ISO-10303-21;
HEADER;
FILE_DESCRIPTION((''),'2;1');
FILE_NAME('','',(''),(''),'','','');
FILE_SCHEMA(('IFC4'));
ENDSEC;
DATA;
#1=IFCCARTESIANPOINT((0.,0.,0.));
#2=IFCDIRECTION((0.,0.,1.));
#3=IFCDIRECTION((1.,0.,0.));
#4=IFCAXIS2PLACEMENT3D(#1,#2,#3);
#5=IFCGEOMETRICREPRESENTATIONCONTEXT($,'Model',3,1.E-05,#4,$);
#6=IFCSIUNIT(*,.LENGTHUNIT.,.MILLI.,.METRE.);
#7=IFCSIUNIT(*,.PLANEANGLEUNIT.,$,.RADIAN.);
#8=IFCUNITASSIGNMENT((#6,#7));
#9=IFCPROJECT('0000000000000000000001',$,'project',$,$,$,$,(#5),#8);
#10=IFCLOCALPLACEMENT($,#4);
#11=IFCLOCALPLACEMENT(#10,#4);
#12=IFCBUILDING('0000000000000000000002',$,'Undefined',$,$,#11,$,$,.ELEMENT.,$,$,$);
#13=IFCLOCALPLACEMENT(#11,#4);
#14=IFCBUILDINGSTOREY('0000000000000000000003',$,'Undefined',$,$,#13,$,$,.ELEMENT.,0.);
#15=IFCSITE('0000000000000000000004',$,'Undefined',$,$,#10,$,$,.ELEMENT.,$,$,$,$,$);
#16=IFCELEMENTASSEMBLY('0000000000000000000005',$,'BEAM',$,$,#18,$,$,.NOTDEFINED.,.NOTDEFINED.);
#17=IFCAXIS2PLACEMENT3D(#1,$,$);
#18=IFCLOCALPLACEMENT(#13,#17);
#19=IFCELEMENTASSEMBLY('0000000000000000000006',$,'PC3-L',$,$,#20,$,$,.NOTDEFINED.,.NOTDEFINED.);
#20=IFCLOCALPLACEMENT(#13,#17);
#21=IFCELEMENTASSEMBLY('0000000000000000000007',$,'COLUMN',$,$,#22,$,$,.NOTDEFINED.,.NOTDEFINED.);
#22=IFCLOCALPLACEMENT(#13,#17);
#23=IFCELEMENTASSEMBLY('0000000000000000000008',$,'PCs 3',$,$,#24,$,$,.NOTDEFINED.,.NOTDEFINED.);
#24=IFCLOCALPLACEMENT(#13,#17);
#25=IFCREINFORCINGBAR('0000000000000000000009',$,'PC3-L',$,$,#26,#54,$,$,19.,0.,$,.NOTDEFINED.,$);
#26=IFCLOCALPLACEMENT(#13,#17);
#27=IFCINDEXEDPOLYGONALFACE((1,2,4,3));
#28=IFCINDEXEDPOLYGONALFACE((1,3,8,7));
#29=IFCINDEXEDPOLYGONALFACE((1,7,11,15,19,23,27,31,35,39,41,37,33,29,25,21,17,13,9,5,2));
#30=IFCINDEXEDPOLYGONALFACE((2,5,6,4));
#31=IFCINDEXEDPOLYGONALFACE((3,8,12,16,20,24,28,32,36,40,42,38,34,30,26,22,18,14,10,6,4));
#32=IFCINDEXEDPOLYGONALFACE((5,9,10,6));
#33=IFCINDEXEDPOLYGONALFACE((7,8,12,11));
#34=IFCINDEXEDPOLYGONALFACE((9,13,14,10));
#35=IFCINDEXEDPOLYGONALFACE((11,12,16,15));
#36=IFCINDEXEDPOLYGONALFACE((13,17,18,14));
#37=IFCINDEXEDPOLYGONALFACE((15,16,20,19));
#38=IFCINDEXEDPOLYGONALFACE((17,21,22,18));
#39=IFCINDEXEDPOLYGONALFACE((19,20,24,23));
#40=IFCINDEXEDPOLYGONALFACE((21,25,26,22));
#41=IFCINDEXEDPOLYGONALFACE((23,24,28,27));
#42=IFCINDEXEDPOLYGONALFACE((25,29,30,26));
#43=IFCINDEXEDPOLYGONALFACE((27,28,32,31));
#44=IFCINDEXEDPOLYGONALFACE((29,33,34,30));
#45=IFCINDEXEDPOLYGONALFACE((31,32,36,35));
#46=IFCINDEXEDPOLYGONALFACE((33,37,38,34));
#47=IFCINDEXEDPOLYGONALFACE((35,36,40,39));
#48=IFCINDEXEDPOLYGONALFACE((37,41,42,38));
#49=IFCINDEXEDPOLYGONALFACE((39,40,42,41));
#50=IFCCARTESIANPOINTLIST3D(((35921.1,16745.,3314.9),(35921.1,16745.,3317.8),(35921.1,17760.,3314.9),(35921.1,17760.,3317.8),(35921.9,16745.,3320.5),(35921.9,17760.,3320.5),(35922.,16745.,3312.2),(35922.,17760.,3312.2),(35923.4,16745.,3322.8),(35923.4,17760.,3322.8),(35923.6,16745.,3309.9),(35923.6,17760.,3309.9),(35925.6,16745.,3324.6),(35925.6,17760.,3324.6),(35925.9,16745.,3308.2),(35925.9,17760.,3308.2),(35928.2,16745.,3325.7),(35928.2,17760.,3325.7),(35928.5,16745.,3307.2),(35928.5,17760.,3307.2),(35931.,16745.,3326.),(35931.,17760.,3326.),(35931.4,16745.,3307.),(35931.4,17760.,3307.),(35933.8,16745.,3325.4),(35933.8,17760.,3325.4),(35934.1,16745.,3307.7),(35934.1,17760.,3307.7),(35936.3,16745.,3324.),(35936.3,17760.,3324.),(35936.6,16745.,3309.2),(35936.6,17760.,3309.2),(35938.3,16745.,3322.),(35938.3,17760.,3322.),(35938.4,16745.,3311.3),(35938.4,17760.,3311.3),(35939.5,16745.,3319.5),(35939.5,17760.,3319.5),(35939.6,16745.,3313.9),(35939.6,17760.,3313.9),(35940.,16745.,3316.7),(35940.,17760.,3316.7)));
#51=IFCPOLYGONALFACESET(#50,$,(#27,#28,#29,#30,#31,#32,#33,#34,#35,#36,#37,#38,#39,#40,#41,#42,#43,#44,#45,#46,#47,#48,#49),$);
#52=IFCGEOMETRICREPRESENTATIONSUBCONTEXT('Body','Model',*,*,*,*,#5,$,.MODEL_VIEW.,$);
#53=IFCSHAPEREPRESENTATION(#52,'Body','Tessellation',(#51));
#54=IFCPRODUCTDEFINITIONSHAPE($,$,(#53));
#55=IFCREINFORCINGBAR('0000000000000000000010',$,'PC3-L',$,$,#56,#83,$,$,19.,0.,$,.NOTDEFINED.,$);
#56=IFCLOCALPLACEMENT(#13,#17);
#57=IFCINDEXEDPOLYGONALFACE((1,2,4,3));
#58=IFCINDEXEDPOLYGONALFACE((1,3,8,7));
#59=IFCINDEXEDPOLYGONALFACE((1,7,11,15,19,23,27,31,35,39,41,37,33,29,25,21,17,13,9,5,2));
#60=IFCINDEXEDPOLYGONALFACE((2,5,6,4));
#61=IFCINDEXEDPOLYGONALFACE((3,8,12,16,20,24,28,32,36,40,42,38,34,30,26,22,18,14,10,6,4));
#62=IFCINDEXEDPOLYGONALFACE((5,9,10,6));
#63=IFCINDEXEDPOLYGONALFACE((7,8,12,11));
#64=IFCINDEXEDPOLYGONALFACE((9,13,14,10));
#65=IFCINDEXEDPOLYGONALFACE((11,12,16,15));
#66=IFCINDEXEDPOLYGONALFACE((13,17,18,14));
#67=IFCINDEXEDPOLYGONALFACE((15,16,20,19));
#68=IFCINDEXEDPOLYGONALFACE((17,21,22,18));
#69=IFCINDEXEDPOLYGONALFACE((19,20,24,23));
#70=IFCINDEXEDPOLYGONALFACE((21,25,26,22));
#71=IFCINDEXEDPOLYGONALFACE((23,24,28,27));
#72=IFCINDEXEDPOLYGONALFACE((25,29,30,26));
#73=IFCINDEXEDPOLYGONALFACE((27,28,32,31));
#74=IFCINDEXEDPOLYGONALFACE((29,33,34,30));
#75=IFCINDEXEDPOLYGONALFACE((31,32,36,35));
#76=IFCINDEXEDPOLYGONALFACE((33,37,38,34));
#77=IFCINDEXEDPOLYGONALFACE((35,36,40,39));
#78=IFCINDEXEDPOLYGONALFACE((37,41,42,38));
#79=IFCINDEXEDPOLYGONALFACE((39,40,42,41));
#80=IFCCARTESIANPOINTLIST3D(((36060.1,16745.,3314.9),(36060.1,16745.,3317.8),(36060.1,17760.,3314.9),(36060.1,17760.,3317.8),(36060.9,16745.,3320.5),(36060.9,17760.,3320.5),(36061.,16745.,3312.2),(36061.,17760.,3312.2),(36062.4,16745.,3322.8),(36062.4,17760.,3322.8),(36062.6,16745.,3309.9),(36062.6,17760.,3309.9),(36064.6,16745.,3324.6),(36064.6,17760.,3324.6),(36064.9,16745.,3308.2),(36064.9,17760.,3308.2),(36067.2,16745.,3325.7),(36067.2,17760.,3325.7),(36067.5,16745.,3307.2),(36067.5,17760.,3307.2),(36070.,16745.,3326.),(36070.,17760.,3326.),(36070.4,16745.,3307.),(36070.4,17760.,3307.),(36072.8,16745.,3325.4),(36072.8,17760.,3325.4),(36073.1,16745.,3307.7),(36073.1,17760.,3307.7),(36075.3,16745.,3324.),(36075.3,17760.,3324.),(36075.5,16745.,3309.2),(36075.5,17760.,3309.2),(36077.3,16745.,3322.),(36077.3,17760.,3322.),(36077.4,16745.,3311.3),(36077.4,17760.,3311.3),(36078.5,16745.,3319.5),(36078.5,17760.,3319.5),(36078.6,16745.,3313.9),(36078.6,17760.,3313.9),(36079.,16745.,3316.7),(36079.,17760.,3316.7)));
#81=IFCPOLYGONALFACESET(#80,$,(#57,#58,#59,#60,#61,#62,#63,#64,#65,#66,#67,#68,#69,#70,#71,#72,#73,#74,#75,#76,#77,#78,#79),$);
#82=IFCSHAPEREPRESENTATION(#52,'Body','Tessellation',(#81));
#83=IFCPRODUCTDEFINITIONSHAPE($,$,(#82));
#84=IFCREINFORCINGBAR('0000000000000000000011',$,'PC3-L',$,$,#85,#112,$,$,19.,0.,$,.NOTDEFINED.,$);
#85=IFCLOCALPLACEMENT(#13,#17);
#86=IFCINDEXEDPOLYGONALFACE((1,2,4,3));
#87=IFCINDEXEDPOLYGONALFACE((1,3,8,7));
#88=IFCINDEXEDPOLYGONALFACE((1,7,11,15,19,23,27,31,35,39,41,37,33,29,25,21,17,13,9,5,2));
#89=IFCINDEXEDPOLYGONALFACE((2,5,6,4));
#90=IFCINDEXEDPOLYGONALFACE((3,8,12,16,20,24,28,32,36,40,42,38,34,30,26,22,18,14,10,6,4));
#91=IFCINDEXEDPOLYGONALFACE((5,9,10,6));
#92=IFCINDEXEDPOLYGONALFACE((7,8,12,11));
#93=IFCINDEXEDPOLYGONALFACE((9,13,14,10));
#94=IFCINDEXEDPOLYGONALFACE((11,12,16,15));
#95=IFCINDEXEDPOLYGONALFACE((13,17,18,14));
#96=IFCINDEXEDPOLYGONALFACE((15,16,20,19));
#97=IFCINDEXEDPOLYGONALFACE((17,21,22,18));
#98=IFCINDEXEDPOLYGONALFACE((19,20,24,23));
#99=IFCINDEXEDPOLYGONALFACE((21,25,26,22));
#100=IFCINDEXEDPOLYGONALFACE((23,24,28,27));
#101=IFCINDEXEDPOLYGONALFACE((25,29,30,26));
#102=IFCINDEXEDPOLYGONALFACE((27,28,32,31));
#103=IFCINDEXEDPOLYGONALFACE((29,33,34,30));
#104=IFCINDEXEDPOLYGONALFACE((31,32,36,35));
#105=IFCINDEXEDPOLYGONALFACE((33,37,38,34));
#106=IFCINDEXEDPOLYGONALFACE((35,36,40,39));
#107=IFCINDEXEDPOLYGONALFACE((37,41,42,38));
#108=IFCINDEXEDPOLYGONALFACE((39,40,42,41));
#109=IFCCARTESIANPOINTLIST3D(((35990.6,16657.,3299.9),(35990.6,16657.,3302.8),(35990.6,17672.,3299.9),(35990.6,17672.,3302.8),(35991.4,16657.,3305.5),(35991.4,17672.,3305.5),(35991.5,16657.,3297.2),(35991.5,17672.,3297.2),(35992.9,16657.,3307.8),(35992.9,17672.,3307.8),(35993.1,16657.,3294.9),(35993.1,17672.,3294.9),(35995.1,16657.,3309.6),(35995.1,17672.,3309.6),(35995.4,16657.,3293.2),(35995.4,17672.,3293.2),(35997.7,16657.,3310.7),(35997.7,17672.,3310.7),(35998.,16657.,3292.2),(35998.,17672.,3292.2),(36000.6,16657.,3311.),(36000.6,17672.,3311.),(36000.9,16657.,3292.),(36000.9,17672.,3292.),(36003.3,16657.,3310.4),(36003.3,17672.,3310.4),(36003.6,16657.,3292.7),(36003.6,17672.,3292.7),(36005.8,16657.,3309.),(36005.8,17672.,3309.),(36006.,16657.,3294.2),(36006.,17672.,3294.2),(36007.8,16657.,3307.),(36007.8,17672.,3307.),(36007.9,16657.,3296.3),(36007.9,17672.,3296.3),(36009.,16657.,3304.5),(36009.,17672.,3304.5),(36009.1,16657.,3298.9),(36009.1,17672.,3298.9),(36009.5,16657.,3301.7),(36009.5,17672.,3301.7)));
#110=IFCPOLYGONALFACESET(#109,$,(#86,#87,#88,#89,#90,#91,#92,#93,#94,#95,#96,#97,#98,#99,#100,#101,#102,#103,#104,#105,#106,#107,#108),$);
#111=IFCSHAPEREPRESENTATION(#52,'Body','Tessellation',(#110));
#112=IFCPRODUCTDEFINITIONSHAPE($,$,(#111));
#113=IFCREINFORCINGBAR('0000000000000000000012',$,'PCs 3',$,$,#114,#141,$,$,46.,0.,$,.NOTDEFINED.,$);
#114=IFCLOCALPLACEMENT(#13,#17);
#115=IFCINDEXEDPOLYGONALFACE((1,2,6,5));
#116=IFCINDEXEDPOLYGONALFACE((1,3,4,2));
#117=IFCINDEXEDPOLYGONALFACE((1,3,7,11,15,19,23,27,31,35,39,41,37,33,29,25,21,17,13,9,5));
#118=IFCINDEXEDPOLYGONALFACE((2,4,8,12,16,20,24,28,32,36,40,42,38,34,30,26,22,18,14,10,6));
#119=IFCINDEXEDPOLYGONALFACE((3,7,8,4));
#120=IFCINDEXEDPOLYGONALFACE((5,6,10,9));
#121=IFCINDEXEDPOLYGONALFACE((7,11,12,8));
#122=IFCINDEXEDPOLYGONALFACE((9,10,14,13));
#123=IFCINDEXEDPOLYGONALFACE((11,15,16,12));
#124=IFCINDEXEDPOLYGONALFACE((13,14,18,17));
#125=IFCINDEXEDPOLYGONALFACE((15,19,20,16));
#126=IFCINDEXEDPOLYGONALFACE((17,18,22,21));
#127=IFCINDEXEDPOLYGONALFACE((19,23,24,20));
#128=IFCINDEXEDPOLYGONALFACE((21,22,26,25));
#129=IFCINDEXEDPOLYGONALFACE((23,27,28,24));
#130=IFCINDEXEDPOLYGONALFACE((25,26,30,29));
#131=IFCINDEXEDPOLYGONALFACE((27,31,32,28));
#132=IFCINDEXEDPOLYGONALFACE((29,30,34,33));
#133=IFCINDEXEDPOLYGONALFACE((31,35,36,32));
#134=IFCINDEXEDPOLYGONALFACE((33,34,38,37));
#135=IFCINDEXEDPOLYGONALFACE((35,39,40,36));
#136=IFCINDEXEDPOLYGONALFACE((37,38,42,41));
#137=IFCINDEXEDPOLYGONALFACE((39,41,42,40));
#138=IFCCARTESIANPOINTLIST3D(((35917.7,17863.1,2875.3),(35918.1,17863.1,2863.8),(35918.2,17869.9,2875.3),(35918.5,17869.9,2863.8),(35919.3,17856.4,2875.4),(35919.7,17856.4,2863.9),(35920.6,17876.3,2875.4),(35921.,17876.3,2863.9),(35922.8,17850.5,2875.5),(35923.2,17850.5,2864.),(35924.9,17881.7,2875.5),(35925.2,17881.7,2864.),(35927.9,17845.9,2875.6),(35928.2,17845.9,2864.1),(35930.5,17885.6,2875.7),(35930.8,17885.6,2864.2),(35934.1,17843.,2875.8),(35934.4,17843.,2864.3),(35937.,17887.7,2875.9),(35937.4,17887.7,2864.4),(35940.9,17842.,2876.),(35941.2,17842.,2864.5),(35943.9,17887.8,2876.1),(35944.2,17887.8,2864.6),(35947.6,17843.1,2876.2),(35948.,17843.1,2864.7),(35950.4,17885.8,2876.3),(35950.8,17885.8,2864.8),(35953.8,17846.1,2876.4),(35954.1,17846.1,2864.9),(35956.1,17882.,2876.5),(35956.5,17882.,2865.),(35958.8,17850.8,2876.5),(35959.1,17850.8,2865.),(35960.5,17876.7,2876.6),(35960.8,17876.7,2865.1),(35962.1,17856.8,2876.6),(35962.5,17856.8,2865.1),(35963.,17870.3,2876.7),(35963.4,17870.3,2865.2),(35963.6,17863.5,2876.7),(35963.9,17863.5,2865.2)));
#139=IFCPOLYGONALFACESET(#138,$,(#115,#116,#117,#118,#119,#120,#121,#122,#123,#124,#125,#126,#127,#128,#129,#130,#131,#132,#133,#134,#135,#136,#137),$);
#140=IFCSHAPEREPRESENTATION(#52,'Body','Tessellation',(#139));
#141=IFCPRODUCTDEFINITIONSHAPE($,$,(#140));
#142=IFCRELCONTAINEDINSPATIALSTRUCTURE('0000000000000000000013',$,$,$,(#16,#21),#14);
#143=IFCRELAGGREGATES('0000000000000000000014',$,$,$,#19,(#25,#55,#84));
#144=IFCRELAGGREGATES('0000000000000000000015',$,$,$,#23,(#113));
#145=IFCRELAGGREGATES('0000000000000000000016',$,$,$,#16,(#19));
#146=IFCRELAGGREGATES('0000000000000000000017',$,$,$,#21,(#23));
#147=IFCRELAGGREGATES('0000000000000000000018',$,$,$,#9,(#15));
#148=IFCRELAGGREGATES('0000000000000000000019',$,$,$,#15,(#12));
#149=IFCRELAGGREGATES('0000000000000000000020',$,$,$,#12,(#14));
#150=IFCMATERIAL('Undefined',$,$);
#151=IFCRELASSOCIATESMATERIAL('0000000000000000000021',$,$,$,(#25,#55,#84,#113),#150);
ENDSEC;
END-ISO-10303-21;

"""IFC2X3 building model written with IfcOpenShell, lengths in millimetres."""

from ifc_helpers import new_model, entity, si_unit, frame, origin_with_axes, place, context, subcontext, project, spatial, source, transform, mapped, material, element, aggregate, save


model = new_model("IFC2X3")

# Units and contexts
model_context = context("Model", 3, precision=1e-05, world=origin_with_axes())
body_context = subcontext(model_context, "Body", "Model", "MODEL_VIEW")
ifc_project = project(units=[si_unit("LENGTHUNIT", "METRE", prefix="MILLI"), si_unit("PLANEANGLEUNIT", "RADIAN")], contexts=[model_context])

# Site, building, storey
site_placement = place(None, origin_with_axes())
site = spatial("IfcSite", under=ifc_project, at=site_placement, Name="Undefined", CompositionType="ELEMENT")
building_placement = place(site_placement, origin_with_axes())
building = spatial("IfcBuilding", under=site, at=building_placement, Name="Undefined", CompositionType="ELEMENT")
storey_placement = place(building_placement, origin_with_axes())
storey = spatial("IfcBuildingStorey", under=building, at=storey_placement, Name="Undefined", CompositionType="ELEMENT", Elevation=0.0)

# Element assemblies
assembly_1_placement = place(storey_placement, origin_with_axes())
assembly_1 = element("IfcElementAssembly", 1, at=assembly_1_placement, inside=storey, Name="BEAM", AssemblyPlace="NOTDEFINED", PredefinedType="NOTDEFINED")
assembly_2_placement = place(assembly_1_placement, origin_with_axes())
assembly_2 = element("IfcElementAssembly", 2, at=assembly_2_placement, Name="PC3-L", AssemblyPlace="NOTDEFINED", PredefinedType="NOTDEFINED")

# Element assemblies
assembly_3_placement = place(storey_placement, origin_with_axes())
assembly_3 = element("IfcElementAssembly", 3, at=assembly_3_placement, inside=storey, Name="COLUMN", AssemblyPlace="NOTDEFINED", PredefinedType="NOTDEFINED")
assembly_4_placement = place(assembly_3_placement, origin_with_axes())
assembly_4 = element("IfcElementAssembly", 4, at=assembly_4_placement, Name="PCs 3", AssemblyPlace="NOTDEFINED", PredefinedType="NOTDEFINED")

# Reinforcing bars
ifc_material_1 = material(Name="Undefined")
shared_shape_1 = source(origin_with_axes(), body_context, "Body", "AdvancedSweptSolid", [
    entity("IfcSweptDiskSolid", entity("IfcTrimmedCurve", entity("IfcLine", entity("IfcCartesianPoint", [0.0, 0.0, 0.0]), entity("IfcVector", entity("IfcDirection", [1.0, 0.0, 0.0]), 1.0)), [entity("IfcParameterValue", 0.0)], [entity("IfcParameterValue", 1015.0)], True, "PARAMETER"), 9.5, None, 0.0, 1015.0),
])
reinforcing_bar_1_placement = place(assembly_2_placement, frame((35930.5, 17760.0, 3316.5), z_axis=(0.091912, 0.0, -0.995767), x_axis=(0.0, -1.0, 0.0)))
reinforcing_bar_1 = element("IfcReinforcingBar", 5, at=reinforcing_bar_1_placement, material=ifc_material_1, Name="PC3-L", BarRole="NOTDEFINED", CrossSectionArea=0.0, NominalDiameter=19.0, context=body_context, shape_type="MappedRepresentation", body=[
    mapped(shared_shape_1, transform((0.0, 0.0, 0.0))),
])
shared_shape_2 = source(origin_with_axes(), body_context, "Body", "AdvancedSweptSolid", [
    entity("IfcSweptDiskSolid", entity("IfcTrimmedCurve", entity("IfcLine", entity("IfcCartesianPoint", [0.0, 0.0, 0.0]), entity("IfcVector", entity("IfcDirection", [1.0, 0.0, 0.0]), 1.0)), [entity("IfcParameterValue", 0.0)], [entity("IfcParameterValue", 1015.0)], True, "PARAMETER"), 9.5, None, 0.0, 1015.0),
])
reinforcing_bar_2_placement = place(assembly_2_placement, frame((36069.5, 17760.0, 3316.5), z_axis=(0.091561, 0.0, -0.995799), x_axis=(0.0, -1.0, 0.0)))
reinforcing_bar_2 = element("IfcReinforcingBar", 6, at=reinforcing_bar_2_placement, material=ifc_material_1, Name="PC3-L", BarRole="NOTDEFINED", CrossSectionArea=0.0, NominalDiameter=19.0, context=body_context, shape_type="MappedRepresentation", body=[
    mapped(shared_shape_2, transform((0.0, 0.0, 0.0))),
])
shared_shape_3 = source(origin_with_axes(), body_context, "Body", "AdvancedSweptSolid", [
    entity("IfcSweptDiskSolid", entity("IfcTrimmedCurve", entity("IfcLine", entity("IfcCartesianPoint", [0.0, 0.0, 0.0]), entity("IfcVector", entity("IfcDirection", [1.0, 0.0, 0.0]), 1.0)), [entity("IfcParameterValue", 0.0)], [entity("IfcParameterValue", 1015.0)], True, "PARAMETER"), 9.5, None, 0.0, 1015.0),
])
reinforcing_bar_3_placement = place(assembly_2_placement, frame((36000.0, 17672.0, 3301.5), z_axis=(0.091325, 0.0, -0.995821), x_axis=(0.0, -1.0, 0.0)))
reinforcing_bar_3 = element("IfcReinforcingBar", 7, at=reinforcing_bar_3_placement, material=ifc_material_1, Name="PC3-L", BarRole="NOTDEFINED", CrossSectionArea=0.0, NominalDiameter=19.0, context=body_context, shape_type="MappedRepresentation", body=[
    mapped(shared_shape_3, transform((0.0, 0.0, 0.0))),
])
aggregate(assembly_2, [reinforcing_bar_1, reinforcing_bar_2, reinforcing_bar_3])
shared_shape_4 = source(origin_with_axes(), body_context, "Body", "AdvancedSweptSolid", [
    entity("IfcSweptDiskSolid", entity("IfcTrimmedCurve", entity("IfcLine", entity("IfcCartesianPoint", [0.0, 0.0, 0.0]), entity("IfcVector", entity("IfcDirection", [1.0, 0.0, 0.0]), 1.0)), [entity("IfcParameterValue", 0.0)], [entity("IfcParameterValue", 11.5)], True, "PARAMETER"), 23.0, None, 0.0, 11.5),
])
reinforcing_bar_4_placement = place(assembly_4_placement, frame((35940.7, 17865.0, 2876.0), z_axis=(-0.442221, 0.896808, -0.013263), x_axis=(0.029977, 0.0, -0.999551)))
reinforcing_bar_4 = element("IfcReinforcingBar", 8, at=reinforcing_bar_4_placement, material=ifc_material_1, Name="PCs 3", BarRole="NOTDEFINED", CrossSectionArea=0.0, NominalDiameter=46.0, context=body_context, shape_type="MappedRepresentation", body=[
    mapped(shared_shape_4, transform((0.0, 0.0, 0.0))),
])
aggregate(assembly_4, [reinforcing_bar_4])

aggregate(assembly_1, [assembly_2])

aggregate(assembly_3, [assembly_4])

save(model, "model.ifc")
